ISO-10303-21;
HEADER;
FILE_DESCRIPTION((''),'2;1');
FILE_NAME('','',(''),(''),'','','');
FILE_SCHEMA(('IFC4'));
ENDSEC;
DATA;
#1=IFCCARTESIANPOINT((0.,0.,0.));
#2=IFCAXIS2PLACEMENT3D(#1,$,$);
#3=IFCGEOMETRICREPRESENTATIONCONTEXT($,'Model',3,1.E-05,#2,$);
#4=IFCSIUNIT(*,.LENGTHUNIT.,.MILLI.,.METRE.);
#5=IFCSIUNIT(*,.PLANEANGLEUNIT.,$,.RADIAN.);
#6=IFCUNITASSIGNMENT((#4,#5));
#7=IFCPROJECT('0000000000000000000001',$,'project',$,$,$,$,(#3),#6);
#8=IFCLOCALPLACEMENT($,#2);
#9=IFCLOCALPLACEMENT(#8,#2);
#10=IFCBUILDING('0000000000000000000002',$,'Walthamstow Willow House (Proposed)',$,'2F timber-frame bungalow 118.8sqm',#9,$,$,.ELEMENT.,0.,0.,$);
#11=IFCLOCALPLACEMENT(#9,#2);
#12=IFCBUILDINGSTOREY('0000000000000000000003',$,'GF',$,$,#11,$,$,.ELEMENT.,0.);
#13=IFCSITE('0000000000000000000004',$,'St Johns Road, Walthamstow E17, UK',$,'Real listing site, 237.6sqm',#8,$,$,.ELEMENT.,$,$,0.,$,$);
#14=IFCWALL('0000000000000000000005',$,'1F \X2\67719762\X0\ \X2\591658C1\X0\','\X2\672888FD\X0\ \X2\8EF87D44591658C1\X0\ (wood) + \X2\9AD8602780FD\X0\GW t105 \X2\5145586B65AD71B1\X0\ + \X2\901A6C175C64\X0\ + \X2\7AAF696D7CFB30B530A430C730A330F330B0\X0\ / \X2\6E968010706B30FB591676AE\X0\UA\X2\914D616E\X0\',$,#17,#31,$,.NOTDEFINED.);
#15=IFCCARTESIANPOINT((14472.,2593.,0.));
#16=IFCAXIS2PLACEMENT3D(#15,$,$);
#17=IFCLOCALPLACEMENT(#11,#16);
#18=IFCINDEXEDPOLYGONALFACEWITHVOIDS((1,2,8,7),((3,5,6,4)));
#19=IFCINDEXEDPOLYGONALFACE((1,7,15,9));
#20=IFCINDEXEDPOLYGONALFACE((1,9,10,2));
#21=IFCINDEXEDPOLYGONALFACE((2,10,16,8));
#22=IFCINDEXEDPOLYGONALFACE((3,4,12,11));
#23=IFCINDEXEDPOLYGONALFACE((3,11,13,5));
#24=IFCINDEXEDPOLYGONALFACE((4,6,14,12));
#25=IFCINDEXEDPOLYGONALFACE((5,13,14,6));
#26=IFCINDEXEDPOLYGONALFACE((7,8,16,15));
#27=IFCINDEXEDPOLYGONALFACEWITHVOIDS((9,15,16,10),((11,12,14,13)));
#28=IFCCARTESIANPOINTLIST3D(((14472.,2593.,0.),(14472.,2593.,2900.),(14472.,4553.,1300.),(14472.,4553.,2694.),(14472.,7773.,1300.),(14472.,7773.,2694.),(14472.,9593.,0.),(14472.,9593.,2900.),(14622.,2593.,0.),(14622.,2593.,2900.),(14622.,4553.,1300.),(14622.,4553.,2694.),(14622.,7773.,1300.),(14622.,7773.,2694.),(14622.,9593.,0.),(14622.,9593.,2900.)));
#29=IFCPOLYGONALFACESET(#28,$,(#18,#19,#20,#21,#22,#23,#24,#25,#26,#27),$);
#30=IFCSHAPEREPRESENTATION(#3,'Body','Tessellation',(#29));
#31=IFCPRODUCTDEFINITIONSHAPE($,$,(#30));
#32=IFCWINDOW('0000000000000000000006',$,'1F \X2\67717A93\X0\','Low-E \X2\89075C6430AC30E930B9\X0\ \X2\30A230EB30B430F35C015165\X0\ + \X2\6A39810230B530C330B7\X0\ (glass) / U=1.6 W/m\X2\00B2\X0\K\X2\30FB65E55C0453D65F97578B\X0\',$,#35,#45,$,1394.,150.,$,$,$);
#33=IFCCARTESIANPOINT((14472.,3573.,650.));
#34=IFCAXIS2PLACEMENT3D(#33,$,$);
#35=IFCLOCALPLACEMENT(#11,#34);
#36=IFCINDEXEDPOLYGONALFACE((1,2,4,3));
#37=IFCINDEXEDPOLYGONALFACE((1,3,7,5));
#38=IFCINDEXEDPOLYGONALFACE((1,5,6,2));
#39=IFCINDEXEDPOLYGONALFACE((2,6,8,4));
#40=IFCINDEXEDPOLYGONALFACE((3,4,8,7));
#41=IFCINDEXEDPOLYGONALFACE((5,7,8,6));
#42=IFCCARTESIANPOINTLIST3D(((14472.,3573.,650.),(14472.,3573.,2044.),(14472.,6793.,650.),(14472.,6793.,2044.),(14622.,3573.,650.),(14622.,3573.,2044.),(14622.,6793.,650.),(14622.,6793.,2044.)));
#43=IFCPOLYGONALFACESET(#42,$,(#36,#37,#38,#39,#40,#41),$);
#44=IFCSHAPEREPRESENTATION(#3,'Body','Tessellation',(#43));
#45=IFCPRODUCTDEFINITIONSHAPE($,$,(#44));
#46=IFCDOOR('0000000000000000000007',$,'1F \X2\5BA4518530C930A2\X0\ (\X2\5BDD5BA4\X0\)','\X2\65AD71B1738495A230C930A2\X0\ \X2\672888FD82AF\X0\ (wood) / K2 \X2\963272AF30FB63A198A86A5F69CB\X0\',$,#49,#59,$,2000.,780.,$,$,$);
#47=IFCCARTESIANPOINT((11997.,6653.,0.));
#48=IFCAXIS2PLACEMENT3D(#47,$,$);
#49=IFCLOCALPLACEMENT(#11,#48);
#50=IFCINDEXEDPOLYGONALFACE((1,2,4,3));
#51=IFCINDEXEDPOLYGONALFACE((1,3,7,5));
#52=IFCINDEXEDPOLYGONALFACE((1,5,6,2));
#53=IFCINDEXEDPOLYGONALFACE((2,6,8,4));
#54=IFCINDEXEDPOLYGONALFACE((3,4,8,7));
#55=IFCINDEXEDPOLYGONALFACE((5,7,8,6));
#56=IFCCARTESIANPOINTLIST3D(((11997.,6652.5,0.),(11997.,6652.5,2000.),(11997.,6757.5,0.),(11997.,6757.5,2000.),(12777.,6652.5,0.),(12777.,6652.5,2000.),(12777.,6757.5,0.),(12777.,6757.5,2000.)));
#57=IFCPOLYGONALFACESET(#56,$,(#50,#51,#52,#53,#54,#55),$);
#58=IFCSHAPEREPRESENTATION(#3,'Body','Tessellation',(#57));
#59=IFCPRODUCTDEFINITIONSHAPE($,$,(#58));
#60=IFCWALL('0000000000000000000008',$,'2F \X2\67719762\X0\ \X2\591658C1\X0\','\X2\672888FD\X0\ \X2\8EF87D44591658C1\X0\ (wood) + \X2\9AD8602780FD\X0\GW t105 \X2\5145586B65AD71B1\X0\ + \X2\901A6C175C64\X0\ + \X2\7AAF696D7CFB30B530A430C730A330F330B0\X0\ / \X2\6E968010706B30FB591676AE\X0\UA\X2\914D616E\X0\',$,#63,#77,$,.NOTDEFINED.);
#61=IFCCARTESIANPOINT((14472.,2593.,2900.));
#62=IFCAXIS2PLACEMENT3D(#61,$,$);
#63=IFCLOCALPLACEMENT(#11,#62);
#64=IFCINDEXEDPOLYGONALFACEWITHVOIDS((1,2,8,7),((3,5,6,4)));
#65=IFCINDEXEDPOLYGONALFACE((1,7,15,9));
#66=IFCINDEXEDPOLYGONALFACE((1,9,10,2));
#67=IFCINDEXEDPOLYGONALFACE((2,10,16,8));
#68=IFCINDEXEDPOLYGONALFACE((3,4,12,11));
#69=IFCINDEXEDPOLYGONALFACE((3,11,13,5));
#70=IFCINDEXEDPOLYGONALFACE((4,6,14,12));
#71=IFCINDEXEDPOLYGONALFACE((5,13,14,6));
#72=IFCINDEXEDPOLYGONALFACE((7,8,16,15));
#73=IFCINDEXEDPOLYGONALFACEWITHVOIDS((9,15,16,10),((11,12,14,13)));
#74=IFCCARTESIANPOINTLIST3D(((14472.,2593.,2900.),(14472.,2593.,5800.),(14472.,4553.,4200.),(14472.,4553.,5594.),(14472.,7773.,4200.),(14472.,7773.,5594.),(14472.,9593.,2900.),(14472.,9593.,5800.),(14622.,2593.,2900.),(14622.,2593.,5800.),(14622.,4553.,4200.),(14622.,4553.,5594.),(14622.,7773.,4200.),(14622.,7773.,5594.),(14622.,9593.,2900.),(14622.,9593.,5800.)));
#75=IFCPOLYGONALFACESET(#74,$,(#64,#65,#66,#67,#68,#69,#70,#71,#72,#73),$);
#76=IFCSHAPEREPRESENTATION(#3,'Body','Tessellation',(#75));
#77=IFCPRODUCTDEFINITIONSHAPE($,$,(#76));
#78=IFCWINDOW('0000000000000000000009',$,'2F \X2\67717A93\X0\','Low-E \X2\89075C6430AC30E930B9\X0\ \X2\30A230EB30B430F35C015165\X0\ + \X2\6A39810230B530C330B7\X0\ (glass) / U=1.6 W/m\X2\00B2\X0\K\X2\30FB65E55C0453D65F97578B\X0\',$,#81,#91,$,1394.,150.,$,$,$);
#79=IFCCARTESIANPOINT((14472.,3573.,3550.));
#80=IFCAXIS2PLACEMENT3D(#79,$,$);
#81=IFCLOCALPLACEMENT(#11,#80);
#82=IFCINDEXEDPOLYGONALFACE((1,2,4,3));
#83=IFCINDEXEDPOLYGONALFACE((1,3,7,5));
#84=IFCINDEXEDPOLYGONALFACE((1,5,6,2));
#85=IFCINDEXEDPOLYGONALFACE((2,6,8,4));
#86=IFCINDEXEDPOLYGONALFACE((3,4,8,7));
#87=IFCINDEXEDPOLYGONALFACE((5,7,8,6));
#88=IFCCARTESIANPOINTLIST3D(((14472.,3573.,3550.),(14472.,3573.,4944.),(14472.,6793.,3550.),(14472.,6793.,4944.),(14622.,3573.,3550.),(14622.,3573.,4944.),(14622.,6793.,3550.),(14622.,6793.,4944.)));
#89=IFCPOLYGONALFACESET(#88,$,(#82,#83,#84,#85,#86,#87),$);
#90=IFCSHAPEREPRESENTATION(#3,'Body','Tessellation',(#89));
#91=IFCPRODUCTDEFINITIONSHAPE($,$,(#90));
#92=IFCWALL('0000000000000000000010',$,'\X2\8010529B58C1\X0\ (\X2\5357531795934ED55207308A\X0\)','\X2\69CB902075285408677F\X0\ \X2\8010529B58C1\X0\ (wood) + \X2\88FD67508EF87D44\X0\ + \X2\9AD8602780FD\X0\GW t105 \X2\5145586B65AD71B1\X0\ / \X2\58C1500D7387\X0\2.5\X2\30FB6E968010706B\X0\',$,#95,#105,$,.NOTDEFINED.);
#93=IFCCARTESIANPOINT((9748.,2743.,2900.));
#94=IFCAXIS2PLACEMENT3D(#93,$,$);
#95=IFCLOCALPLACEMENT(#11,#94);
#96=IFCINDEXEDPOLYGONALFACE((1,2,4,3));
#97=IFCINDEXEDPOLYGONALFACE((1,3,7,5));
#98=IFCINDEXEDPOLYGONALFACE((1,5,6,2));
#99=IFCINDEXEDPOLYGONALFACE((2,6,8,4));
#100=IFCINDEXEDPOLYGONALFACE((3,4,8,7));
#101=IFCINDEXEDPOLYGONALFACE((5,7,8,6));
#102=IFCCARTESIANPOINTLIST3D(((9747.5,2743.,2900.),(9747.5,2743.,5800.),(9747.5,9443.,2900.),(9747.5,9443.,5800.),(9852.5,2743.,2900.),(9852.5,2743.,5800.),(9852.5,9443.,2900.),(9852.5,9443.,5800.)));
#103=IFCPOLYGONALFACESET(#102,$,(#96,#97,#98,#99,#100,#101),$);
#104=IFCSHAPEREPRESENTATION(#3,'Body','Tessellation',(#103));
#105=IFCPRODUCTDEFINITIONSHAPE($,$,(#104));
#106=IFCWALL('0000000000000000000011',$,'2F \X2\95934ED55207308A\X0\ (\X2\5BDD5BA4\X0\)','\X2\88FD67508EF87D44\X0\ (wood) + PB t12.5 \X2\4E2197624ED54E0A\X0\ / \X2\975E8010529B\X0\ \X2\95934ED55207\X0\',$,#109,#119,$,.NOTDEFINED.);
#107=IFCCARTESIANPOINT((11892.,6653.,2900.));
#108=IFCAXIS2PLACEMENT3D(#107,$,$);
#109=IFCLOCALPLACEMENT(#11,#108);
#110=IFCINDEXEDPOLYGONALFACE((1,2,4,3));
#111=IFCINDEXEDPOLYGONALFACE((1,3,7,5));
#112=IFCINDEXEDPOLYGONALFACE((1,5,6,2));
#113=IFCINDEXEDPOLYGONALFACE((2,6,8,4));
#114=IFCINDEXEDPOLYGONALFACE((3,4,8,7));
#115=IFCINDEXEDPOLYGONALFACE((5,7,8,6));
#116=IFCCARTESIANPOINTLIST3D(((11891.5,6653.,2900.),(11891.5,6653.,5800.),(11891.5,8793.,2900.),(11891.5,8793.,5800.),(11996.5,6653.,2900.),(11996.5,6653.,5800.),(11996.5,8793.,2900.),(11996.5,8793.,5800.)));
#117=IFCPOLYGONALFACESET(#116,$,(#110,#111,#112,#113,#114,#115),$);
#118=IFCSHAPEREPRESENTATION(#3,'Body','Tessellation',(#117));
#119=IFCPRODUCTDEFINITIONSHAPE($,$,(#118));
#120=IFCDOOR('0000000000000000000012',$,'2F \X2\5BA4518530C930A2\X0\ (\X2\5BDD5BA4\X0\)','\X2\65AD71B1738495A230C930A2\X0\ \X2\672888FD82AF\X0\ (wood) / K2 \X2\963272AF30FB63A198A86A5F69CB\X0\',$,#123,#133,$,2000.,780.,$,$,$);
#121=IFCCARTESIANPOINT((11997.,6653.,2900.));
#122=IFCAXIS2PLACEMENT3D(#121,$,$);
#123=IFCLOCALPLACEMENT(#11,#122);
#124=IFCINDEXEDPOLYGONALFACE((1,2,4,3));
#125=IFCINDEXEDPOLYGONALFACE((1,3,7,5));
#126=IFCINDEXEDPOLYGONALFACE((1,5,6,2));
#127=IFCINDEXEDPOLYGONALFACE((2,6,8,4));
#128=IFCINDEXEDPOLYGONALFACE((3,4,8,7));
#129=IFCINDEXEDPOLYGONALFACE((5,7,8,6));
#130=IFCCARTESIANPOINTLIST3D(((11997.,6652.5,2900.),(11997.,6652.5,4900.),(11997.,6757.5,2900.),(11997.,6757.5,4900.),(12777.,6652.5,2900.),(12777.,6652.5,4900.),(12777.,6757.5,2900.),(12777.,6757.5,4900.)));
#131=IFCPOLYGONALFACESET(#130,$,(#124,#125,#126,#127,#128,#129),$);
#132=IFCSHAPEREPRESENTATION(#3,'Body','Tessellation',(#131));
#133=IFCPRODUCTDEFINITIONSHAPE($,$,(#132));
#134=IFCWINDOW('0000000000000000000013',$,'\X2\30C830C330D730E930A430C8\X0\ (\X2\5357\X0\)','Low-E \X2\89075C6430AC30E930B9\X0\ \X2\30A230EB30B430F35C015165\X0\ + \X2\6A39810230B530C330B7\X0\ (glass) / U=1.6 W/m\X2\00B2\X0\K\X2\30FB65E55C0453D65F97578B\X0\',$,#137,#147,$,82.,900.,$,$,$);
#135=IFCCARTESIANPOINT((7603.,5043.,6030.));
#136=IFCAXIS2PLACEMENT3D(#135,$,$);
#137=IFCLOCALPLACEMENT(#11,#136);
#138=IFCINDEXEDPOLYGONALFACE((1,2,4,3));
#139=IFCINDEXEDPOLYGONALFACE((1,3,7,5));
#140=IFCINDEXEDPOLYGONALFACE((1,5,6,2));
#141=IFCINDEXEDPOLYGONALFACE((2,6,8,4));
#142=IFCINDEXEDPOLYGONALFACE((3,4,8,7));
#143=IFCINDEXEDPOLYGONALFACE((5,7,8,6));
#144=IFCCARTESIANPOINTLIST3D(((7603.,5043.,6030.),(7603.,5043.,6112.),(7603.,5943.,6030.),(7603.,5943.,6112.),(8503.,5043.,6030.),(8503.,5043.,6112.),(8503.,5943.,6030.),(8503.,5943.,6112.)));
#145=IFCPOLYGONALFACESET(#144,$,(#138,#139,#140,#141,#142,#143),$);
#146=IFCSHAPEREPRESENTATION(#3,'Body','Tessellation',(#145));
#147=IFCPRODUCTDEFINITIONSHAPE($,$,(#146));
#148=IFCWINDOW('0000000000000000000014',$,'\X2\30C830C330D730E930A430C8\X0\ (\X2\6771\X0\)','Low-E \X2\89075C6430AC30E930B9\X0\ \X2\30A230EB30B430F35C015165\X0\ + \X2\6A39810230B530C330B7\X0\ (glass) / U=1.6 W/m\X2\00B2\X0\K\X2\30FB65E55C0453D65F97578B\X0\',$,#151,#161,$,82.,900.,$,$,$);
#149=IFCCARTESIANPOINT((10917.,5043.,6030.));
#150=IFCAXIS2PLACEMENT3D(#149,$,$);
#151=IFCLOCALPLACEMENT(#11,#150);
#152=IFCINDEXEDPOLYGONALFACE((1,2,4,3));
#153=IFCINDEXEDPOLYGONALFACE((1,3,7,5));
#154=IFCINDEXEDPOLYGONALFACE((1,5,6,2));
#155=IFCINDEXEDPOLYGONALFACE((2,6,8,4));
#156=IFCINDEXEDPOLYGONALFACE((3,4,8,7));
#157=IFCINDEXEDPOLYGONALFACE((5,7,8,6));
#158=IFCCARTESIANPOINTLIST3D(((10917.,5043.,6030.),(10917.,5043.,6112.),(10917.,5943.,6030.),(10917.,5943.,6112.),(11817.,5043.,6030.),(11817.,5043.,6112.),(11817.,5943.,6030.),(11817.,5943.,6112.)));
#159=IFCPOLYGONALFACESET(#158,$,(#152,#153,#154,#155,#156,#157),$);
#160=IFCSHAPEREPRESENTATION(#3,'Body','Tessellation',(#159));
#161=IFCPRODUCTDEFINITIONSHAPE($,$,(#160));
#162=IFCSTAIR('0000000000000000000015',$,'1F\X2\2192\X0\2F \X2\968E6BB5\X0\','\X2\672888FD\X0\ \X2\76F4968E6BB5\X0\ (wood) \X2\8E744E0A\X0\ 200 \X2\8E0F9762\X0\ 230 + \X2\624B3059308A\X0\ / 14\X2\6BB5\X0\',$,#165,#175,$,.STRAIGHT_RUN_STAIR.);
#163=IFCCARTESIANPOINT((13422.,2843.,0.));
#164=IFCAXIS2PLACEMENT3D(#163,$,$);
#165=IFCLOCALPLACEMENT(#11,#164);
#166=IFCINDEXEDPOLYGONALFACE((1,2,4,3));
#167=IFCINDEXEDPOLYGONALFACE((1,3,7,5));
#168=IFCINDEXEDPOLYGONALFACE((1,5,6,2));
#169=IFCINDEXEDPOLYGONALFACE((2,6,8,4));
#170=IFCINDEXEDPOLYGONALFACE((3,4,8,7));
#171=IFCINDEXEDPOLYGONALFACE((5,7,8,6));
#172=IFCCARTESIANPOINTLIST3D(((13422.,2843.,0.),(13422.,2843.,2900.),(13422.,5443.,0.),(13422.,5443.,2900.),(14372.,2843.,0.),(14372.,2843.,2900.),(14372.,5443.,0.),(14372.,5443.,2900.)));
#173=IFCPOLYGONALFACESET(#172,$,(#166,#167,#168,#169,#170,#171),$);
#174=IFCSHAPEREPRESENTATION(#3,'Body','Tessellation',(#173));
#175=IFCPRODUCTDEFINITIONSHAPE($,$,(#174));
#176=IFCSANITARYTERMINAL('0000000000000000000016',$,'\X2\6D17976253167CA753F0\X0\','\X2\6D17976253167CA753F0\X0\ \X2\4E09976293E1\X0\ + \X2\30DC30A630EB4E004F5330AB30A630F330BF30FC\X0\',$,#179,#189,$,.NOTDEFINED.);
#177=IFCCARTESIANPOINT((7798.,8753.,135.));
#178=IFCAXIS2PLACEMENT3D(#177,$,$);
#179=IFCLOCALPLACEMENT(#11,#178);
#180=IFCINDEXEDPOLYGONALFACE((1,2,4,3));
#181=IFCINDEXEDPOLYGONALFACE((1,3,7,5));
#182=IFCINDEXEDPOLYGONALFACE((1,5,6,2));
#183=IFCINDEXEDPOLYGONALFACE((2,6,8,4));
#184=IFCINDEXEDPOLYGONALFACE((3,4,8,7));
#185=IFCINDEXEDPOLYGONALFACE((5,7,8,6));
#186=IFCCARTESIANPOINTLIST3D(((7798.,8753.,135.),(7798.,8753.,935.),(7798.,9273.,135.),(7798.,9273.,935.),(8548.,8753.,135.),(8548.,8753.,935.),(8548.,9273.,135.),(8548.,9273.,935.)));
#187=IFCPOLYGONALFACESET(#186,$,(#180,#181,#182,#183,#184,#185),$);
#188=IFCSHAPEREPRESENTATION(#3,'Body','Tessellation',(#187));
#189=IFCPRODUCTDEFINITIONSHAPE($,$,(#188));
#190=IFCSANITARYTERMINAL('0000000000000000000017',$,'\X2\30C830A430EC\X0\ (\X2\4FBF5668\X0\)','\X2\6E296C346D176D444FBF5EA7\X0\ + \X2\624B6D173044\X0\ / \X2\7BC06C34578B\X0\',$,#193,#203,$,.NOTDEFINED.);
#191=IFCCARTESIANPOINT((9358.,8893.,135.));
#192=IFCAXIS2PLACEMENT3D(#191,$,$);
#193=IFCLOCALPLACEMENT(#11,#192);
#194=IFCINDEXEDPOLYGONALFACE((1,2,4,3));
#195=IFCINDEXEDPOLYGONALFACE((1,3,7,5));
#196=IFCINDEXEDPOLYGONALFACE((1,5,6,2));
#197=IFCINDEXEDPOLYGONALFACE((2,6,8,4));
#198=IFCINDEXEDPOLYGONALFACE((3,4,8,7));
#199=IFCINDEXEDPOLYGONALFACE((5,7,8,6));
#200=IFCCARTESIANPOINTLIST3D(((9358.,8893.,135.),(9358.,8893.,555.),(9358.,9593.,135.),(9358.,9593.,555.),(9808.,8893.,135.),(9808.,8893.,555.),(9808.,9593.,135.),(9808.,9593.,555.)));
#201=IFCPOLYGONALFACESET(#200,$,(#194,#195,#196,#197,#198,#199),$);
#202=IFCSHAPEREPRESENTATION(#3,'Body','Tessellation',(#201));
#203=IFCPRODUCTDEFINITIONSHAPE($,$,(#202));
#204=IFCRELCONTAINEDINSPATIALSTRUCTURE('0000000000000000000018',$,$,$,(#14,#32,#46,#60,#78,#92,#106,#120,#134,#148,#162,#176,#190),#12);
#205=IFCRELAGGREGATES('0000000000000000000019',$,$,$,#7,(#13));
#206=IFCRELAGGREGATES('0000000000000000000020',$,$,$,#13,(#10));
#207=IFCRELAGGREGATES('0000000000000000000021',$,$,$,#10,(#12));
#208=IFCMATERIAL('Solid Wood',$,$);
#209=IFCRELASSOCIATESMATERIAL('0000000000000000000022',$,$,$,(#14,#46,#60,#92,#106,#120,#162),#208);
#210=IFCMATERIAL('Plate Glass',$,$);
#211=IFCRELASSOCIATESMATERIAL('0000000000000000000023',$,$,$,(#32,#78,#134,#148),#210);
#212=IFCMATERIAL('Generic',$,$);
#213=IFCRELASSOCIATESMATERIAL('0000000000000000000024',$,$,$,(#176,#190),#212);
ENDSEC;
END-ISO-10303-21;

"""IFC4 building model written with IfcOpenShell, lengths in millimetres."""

from ifc_helpers import new_model, si_unit, frame, frame_2d, origin, place, context, project, spatial, rectangle, extrude, material, element, fill, save


model = new_model("IFC4")

# Units and contexts
model_context = context("Model", 3, precision=1e-05, world=origin())
ifc_project = project(units=[si_unit("LENGTHUNIT", "METRE", prefix="MILLI"), si_unit("PLANEANGLEUNIT", "RADIAN")], contexts=[model_context])

# Site, building, storey
site_placement = place(None, origin())
site = spatial("IfcSite", under=ifc_project, at=site_placement, Name="St Johns Road, Walthamstow E17, UK", ObjectType="Real listing site, 237.6sqm", CompositionType="ELEMENT", RefElevation=0.0)
building_placement = place(site_placement, origin())
building = spatial("IfcBuilding", under=site, at=building_placement, Name="Walthamstow Willow House (Proposed)", ObjectType="2F timber-frame bungalow 118.8sqm", CompositionType="ELEMENT", ElevationOfRefHeight=0.0, ElevationOfTerrain=0.0)
storey_placement = place(building_placement, origin())
storey = spatial("IfcBuildingStorey", under=building, at=storey_placement, Name="GF", CompositionType="ELEMENT", Elevation=0.0)

# Wall, opening, window
ifc_material_1 = material(Name="Solid Wood")
wall_1_placement = place(storey_placement, frame((14472.0, 2593.0, 0.0)))
wall_1 = element("IfcWall", 1, at=wall_1_placement, inside=storey, material=ifc_material_1, Name="1F 東面 外壁", Description="木製 軸組外壁 (wood) + 高性能GW t105 充填断熱 + 通気層 + 窯業系サイディング / 準耐火・外皮UA配慮", PredefinedType="NOTDEFINED", context=model_context, shape_type="SweptSolid", body=[
    extrude(rectangle(XDim=150.0, YDim=7000.0, at=frame_2d((75.0, 3500.0))), frame((14472.0, 2593.0, 0.0)), (0.0, 0.0, 1.0), 2900.0),
])
opening_1_placement = place(storey_placement, frame((14472.0, 3573.0, 650.0)))
opening_1 = element("IfcOpeningElement", 2, at=opening_1_placement, cuts=wall_1, PredefinedType="NOTDEFINED", context=model_context, shape_type="SweptSolid", body=[
    extrude(rectangle(XDim=150.0, YDim=3220.0, at=frame_2d((75.0, 1610.0))), frame((14472.0, 3573.0, 650.0)), (0.0, 0.0, 1.0), 1394.0),
])
ifc_material_2 = material(Name="Plate Glass")
window_1_placement = place(storey_placement, frame((14472.0, 3573.0, 650.0)))
window_1 = element("IfcWindow", 3, at=window_1_placement, inside=storey, material=ifc_material_2, Name="1F 東窓", Description="Low-E 複層ガラス アルゴン封入 + 樹脂サッシ (glass) / U=1.6 W/m²K・日射取得型", OverallHeight=1394.0, OverallWidth=150.0, context=model_context, shape_type="SweptSolid", body=[
    extrude(rectangle(XDim=150.0, YDim=3220.0, at=frame_2d((75.0, 1610.0))), frame((14472.0, 3573.0, 650.0)), (0.0, 0.0, 1.0), 1394.0),
])
fill(opening_1, window_1)

# Door
door_1_placement = place(storey_placement, frame((11997.0, 6653.0, 0.0)))
element("IfcDoor", 4, at=door_1_placement, inside=storey, material=ifc_material_1, Name="1F 室内ドア (寝室)", Description="断熱玄関ドア 木製芯 (wood) / K2 防犯・採風機構", OverallHeight=2000.0, OverallWidth=780.0, context=model_context, shape_type="SweptSolid", body=[
    extrude(rectangle(XDim=780.0, YDim=105.0, at=frame_2d((390.0, 52.0))), frame((11997.0, 6653.0, 0.0)), (0.0, 0.0, 1.0), 2000.0),
])

# Wall, opening, window
wall_2_placement = place(storey_placement, frame((14472.0, 2593.0, 2900.0)))
wall_2 = element("IfcWall", 5, at=wall_2_placement, inside=storey, material=ifc_material_1, Name="2F 東面 外壁", Description="木製 軸組外壁 (wood) + 高性能GW t105 充填断熱 + 通気層 + 窯業系サイディング / 準耐火・外皮UA配慮", PredefinedType="NOTDEFINED", context=model_context, shape_type="SweptSolid", body=[
    extrude(rectangle(XDim=150.0, YDim=7000.0, at=frame_2d((75.0, 3500.0))), frame((14472.0, 2593.0, 2900.0)), (0.0, 0.0, 1.0), 2900.0),
])
opening_2_placement = place(storey_placement, frame((14472.0, 3573.0, 3550.0)))
opening_2 = element("IfcOpeningElement", 6, at=opening_2_placement, cuts=wall_2, PredefinedType="NOTDEFINED", context=model_context, shape_type="SweptSolid", body=[
    extrude(rectangle(XDim=150.0, YDim=3220.0, at=frame_2d((75.0, 1610.0))), frame((14472.0, 3573.0, 3550.0)), (0.0, 0.0, 1.0), 1394.0),
])
window_2_placement = place(storey_placement, frame((14472.0, 3573.0, 3550.0)))
window_2 = element("IfcWindow", 7, at=window_2_placement, inside=storey, material=ifc_material_2, Name="2F 東窓", Description="Low-E 複層ガラス アルゴン封入 + 樹脂サッシ (glass) / U=1.6 W/m²K・日射取得型", OverallHeight=1394.0, OverallWidth=150.0, context=model_context, shape_type="SweptSolid", body=[
    extrude(rectangle(XDim=150.0, YDim=3220.0, at=frame_2d((75.0, 1610.0))), frame((14472.0, 3573.0, 3550.0)), (0.0, 0.0, 1.0), 1394.0),
])
fill(opening_2, window_2)

# Walls
wall_3_placement = place(storey_placement, frame((9748.0, 2743.0, 2900.0)))
element("IfcWall", 8, at=wall_3_placement, inside=storey, material=ifc_material_1, Name="耐力壁 (南北間仕切り)", Description="構造用合板 耐力壁 (wood) + 製材軸組 + 高性能GW t105 充填断熱 / 壁倍率2.5・準耐火", PredefinedType="NOTDEFINED", context=model_context, shape_type="SweptSolid", body=[
    extrude(rectangle(XDim=105.0, YDim=6700.0, at=frame_2d((52.0, 3350.0))), frame((9748.0, 2743.0, 2900.0)), (0.0, 0.0, 1.0), 2900.0),
])
wall_4_placement = place(storey_placement, frame((11892.0, 6653.0, 2900.0)))
element("IfcWall", 9, at=wall_4_placement, inside=storey, material=ifc_material_1, Name="2F 間仕切り (寝室)", Description="製材軸組 (wood) + PB t12.5 両面仕上 / 非耐力 間仕切", PredefinedType="NOTDEFINED", context=model_context, shape_type="SweptSolid", body=[
    extrude(rectangle(XDim=105.0, YDim=2140.0, at=frame_2d((52.0, 1070.0))), frame((11892.0, 6653.0, 2900.0)), (0.0, 0.0, 1.0), 2900.0),
])

# Door
door_2_placement = place(storey_placement, frame((11997.0, 6653.0, 2900.0)))
element("IfcDoor", 10, at=door_2_placement, inside=storey, material=ifc_material_1, Name="2F 室内ドア (寝室)", Description="断熱玄関ドア 木製芯 (wood) / K2 防犯・採風機構", OverallHeight=2000.0, OverallWidth=780.0, context=model_context, shape_type="SweptSolid", body=[
    extrude(rectangle(XDim=780.0, YDim=105.0, at=frame_2d((390.0, 52.0))), frame((11997.0, 6653.0, 2900.0)), (0.0, 0.0, 1.0), 2000.0),
])

# Windows
window_3_placement = place(storey_placement, frame((7603.0, 5043.0, 6030.0)))
element("IfcWindow", 11, at=window_3_placement, inside=storey, material=ifc_material_2, Name="トップライト (南)", Description="Low-E 複層ガラス アルゴン封入 + 樹脂サッシ (glass) / U=1.6 W/m²K・日射取得型", OverallHeight=82.0, OverallWidth=900.0, context=model_context, shape_type="SweptSolid", body=[
    extrude(rectangle(XDim=900.0, YDim=900.0, at=frame_2d((450.0, 450.0))), frame((7603.0, 5043.0, 6030.0)), (0.0, 0.0, 1.0), 82.0),
])
window_4_placement = place(storey_placement, frame((10917.0, 5043.0, 6030.0)))
element("IfcWindow", 12, at=window_4_placement, inside=storey, material=ifc_material_2, Name="トップライト (東)", Description="Low-E 複層ガラス アルゴン封入 + 樹脂サッシ (glass) / U=1.6 W/m²K・日射取得型", OverallHeight=82.0, OverallWidth=900.0, context=model_context, shape_type="SweptSolid", body=[
    extrude(rectangle(XDim=900.0, YDim=900.0, at=frame_2d((450.0, 450.0))), frame((10917.0, 5043.0, 6030.0)), (0.0, 0.0, 1.0), 82.0),
])

# Stair
stair_placement = place(storey_placement, frame((13422.0, 2843.0, 0.0)))
element("IfcStair", 13, at=stair_placement, inside=storey, material=ifc_material_1, Name="1F→2F 階段", Description="木製 直階段 (wood) 蹴上 200 踏面 230 + 手すり / 14段", PredefinedType="STRAIGHT_RUN_STAIR", context=model_context, shape_type="SweptSolid", body=[
    extrude(rectangle(XDim=950.0, YDim=2600.0, at=frame_2d((475.0, 1300.0))), frame((13422.0, 2843.0, 0.0)), (0.0, 0.0, 1.0), 2900.0),
])

# Sanitary terminals
ifc_material_3 = material(Name="Generic")
sanitary_terminal_1_placement = place(storey_placement, frame((7798.0, 8753.0, 135.0)))
element("IfcSanitaryTerminal", 14, at=sanitary_terminal_1_placement, inside=storey, material=ifc_material_3, Name="洗面化粧台", Description="洗面化粧台 三面鏡 + ボウル一体カウンター", PredefinedType="NOTDEFINED", context=model_context, shape_type="SweptSolid", body=[
    extrude(rectangle(XDim=750.0, YDim=520.0, at=frame_2d((375.0, 260.0))), frame((7798.0, 8753.0, 135.0)), (0.0, 0.0, 1.0), 800.0),
])
sanitary_terminal_2_placement = place(storey_placement, frame((9358.0, 8893.0, 135.0)))
element("IfcSanitaryTerminal", 15, at=sanitary_terminal_2_placement, inside=storey, material=ifc_material_3, Name="トイレ (便器)", Description="温水洗浄便座 + 手洗い / 節水型", PredefinedType="NOTDEFINED", context=model_context, shape_type="SweptSolid", body=[
    extrude(rectangle(XDim=450.0, YDim=700.0, at=frame_2d((225.0, 350.0))), frame((9358.0, 8893.0, 135.0)), (0.0, 0.0, 1.0), 420.0),
])

save(model, "model.ifc")
